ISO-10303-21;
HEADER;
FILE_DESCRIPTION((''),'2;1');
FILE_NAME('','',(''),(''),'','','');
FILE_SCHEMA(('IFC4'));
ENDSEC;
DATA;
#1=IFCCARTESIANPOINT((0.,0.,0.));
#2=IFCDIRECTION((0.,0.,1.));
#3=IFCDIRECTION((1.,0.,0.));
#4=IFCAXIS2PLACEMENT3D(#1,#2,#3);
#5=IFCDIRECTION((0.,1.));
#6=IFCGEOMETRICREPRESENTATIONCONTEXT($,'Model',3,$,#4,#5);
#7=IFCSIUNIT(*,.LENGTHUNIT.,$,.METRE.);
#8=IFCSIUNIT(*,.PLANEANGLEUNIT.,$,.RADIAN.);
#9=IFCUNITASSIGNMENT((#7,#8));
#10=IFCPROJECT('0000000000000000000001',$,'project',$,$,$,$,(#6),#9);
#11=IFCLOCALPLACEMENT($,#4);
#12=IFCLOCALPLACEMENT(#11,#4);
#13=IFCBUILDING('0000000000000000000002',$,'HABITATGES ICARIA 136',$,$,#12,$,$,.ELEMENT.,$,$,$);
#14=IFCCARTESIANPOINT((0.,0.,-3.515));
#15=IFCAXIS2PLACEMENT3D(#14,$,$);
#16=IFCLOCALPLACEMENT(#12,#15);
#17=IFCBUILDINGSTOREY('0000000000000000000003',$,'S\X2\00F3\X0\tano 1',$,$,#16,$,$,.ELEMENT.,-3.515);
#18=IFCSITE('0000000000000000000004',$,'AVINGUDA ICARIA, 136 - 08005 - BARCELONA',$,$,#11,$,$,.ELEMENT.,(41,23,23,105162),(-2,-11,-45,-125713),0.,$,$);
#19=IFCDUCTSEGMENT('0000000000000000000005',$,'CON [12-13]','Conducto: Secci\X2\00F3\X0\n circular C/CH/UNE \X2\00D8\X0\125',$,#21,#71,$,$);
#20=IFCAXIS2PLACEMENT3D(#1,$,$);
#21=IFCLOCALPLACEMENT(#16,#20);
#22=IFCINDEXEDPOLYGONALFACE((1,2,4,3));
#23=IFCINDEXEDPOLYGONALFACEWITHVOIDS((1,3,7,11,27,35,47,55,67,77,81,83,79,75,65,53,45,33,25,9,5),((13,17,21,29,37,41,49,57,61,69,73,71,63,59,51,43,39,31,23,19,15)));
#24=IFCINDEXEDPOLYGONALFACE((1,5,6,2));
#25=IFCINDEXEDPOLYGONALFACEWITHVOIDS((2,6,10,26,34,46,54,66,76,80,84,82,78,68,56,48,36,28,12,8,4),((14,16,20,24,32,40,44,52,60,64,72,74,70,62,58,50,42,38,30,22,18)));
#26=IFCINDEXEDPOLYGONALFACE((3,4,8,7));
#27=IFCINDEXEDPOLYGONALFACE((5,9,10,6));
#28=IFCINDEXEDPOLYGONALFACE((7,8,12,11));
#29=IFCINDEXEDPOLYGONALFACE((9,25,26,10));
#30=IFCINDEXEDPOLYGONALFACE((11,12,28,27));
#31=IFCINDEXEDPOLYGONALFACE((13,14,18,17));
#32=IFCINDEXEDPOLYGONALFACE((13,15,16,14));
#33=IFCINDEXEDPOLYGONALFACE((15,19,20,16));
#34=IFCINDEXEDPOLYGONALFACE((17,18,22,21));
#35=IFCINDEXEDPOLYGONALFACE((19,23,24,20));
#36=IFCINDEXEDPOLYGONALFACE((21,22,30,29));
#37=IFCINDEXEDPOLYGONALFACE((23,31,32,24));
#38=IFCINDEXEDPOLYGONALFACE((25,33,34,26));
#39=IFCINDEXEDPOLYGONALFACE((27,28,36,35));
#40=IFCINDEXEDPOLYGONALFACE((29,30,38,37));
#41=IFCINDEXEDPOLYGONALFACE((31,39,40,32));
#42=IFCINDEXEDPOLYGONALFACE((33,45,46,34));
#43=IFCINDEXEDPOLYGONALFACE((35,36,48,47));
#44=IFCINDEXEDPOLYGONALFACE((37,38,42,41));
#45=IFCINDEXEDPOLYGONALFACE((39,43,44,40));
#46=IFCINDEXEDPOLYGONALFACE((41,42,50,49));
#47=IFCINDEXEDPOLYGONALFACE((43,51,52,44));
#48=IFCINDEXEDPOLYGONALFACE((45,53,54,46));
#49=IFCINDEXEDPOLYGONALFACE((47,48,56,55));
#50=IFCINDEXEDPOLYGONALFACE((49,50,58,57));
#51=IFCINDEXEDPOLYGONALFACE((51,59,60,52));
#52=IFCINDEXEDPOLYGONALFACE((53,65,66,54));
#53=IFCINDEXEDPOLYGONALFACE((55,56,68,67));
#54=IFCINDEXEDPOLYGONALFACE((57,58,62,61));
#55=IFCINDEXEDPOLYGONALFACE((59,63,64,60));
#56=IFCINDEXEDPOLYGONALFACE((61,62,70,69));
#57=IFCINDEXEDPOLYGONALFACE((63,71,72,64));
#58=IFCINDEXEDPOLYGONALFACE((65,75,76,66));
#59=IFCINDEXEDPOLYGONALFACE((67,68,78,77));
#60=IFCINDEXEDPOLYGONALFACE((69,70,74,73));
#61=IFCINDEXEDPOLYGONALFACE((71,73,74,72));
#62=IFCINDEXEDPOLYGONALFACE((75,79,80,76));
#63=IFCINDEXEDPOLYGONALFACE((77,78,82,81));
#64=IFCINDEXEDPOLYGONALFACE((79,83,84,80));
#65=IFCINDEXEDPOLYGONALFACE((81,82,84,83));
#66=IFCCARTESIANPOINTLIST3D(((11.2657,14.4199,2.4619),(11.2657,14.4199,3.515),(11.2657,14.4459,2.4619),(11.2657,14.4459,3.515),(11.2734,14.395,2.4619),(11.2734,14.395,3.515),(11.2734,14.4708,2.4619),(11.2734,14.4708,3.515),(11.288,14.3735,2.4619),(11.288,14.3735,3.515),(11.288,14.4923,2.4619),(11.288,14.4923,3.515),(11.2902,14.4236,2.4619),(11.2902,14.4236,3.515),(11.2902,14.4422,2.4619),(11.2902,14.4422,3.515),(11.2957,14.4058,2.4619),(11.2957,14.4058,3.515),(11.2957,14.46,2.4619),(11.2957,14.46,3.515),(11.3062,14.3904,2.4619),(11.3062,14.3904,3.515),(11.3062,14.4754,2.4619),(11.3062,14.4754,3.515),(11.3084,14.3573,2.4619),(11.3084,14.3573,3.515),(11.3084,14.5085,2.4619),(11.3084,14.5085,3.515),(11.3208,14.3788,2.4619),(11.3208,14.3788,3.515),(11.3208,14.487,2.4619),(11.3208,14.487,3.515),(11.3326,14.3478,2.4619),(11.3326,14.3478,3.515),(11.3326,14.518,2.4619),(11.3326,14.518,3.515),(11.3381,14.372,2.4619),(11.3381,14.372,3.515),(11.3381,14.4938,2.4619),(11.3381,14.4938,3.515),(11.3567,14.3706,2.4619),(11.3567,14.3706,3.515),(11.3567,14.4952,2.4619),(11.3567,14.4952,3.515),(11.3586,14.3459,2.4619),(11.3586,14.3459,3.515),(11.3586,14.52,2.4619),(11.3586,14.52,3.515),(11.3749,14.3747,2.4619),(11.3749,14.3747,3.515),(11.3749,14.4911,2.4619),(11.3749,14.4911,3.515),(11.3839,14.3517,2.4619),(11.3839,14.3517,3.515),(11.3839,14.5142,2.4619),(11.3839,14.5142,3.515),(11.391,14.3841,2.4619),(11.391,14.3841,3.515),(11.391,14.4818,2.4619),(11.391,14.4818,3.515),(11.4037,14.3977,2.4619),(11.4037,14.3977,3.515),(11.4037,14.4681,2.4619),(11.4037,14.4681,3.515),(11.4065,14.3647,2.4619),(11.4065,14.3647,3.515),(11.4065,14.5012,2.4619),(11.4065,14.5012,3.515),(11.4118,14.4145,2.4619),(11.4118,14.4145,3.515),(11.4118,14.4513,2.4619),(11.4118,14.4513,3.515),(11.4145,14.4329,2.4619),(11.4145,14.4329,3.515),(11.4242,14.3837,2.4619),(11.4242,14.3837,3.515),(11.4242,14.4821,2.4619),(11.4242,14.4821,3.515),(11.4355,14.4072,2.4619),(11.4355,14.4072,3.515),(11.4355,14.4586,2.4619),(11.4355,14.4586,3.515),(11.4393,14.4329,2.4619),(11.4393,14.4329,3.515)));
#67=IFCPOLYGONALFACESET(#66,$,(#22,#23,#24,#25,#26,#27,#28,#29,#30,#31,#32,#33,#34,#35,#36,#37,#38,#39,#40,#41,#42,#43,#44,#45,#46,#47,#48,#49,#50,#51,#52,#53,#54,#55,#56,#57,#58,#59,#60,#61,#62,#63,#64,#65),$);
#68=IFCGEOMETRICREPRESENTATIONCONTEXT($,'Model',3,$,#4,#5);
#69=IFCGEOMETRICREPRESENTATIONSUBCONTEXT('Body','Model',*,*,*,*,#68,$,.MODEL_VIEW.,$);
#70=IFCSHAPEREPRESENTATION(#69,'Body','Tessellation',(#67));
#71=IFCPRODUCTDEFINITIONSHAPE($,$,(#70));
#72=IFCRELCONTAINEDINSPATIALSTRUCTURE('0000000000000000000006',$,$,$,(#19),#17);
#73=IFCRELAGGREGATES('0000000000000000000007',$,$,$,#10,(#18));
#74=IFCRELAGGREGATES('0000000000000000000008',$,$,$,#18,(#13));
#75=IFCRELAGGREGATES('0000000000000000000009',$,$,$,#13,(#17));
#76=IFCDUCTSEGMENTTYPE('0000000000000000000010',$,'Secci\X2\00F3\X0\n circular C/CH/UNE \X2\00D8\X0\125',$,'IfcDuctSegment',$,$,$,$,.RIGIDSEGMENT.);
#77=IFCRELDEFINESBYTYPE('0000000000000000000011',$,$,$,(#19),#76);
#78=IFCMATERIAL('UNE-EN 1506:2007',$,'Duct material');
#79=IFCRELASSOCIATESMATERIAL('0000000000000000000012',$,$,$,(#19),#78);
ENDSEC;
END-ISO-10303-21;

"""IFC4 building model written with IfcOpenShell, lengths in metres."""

from ifc_helpers import new_model, si_unit, direction, frame, origin_with_axes, origin_2d_with_axis, place, context, subcontext, project, spatial, hollow_circle, extrude, material, type_object, element, save


model = new_model("IFC4")

# Units and contexts
model_context_1 = context("Model", 3, world=origin_with_axes(), true_north=direction((0.0, 1.0)))
model_context_2 = context("Model", 3, world=origin_with_axes(), true_north=direction((0.0, 1.0)))
body_context_1 = subcontext(model_context_2, "Body", "Model", "MODEL_VIEW")
ifc_project = project(units=[si_unit("LENGTHUNIT", "METRE"), si_unit("PLANEANGLEUNIT", "RADIAN")], contexts=[model_context_1])

# Site, building, storey
site_placement = place(None, origin_with_axes())
site = spatial("IfcSite", under=ifc_project, at=site_placement, Name="AVINGUDA ICARIA, 136 - 08005 - BARCELONA", CompositionType="ELEMENT", RefLatitude=(41, 23, 23, 105162), RefLongitude=(-2, -11, -45, -125713), RefElevation=0.0)
building_placement = place(site_placement, origin_with_axes())
building = spatial("IfcBuilding", under=site, at=building_placement, Name="HABITATGES ICARIA 136", CompositionType="ELEMENT")
storey_placement = place(building_placement, frame((0.0, 0.0, -3.515)))
storey = spatial("IfcBuildingStorey", under=building, at=storey_placement, Name="Sótano 1", CompositionType="ELEMENT", Elevation=-3.515)

# Duct segment
ifc_material_1 = material(Name="UNE-EN 1506:2007", Category="Duct material")
duct_segment_type = type_object("IfcDuctSegmentType", Name="Sección circular C/CH/UNE Ø125", ApplicableOccurrence="IfcDuctSegment", PredefinedType="RIGIDSEGMENT")
placement_1 = place(None, origin_with_axes())
placement_2 = place(placement_1, origin_with_axes())
placement_3 = place(placement_2, frame((0.0, 0.0, -3.515)))
duct_segment_1_placement = place(placement_3, frame((0.0, 0.0, 3.515), z_axis=(0.0, 0.0, 1.0), x_axis=(1.0, 0.0, 0.0)))
element("IfcDuctSegment", 1, at=duct_segment_1_placement, inside=storey, type_object=duct_segment_type, material=ifc_material_1, Name="CON [12-13]", Description="Conducto: Sección circular C/CH/UNE Ø125", context=body_context_1, shape_type="SweptSolid", body=[
    extrude(hollow_circle(Radius=0.0873, WallThickness=0.0248, at=origin_2d_with_axis()), frame((11.352, 14.4329, 0.0), z_axis=(0.0, 0.0, -1.0), x_axis=(1.0, 0.0, 0.0)), (0.0, 0.0, 1.0), 1.0531),
])

save(model, "model.ifc")
